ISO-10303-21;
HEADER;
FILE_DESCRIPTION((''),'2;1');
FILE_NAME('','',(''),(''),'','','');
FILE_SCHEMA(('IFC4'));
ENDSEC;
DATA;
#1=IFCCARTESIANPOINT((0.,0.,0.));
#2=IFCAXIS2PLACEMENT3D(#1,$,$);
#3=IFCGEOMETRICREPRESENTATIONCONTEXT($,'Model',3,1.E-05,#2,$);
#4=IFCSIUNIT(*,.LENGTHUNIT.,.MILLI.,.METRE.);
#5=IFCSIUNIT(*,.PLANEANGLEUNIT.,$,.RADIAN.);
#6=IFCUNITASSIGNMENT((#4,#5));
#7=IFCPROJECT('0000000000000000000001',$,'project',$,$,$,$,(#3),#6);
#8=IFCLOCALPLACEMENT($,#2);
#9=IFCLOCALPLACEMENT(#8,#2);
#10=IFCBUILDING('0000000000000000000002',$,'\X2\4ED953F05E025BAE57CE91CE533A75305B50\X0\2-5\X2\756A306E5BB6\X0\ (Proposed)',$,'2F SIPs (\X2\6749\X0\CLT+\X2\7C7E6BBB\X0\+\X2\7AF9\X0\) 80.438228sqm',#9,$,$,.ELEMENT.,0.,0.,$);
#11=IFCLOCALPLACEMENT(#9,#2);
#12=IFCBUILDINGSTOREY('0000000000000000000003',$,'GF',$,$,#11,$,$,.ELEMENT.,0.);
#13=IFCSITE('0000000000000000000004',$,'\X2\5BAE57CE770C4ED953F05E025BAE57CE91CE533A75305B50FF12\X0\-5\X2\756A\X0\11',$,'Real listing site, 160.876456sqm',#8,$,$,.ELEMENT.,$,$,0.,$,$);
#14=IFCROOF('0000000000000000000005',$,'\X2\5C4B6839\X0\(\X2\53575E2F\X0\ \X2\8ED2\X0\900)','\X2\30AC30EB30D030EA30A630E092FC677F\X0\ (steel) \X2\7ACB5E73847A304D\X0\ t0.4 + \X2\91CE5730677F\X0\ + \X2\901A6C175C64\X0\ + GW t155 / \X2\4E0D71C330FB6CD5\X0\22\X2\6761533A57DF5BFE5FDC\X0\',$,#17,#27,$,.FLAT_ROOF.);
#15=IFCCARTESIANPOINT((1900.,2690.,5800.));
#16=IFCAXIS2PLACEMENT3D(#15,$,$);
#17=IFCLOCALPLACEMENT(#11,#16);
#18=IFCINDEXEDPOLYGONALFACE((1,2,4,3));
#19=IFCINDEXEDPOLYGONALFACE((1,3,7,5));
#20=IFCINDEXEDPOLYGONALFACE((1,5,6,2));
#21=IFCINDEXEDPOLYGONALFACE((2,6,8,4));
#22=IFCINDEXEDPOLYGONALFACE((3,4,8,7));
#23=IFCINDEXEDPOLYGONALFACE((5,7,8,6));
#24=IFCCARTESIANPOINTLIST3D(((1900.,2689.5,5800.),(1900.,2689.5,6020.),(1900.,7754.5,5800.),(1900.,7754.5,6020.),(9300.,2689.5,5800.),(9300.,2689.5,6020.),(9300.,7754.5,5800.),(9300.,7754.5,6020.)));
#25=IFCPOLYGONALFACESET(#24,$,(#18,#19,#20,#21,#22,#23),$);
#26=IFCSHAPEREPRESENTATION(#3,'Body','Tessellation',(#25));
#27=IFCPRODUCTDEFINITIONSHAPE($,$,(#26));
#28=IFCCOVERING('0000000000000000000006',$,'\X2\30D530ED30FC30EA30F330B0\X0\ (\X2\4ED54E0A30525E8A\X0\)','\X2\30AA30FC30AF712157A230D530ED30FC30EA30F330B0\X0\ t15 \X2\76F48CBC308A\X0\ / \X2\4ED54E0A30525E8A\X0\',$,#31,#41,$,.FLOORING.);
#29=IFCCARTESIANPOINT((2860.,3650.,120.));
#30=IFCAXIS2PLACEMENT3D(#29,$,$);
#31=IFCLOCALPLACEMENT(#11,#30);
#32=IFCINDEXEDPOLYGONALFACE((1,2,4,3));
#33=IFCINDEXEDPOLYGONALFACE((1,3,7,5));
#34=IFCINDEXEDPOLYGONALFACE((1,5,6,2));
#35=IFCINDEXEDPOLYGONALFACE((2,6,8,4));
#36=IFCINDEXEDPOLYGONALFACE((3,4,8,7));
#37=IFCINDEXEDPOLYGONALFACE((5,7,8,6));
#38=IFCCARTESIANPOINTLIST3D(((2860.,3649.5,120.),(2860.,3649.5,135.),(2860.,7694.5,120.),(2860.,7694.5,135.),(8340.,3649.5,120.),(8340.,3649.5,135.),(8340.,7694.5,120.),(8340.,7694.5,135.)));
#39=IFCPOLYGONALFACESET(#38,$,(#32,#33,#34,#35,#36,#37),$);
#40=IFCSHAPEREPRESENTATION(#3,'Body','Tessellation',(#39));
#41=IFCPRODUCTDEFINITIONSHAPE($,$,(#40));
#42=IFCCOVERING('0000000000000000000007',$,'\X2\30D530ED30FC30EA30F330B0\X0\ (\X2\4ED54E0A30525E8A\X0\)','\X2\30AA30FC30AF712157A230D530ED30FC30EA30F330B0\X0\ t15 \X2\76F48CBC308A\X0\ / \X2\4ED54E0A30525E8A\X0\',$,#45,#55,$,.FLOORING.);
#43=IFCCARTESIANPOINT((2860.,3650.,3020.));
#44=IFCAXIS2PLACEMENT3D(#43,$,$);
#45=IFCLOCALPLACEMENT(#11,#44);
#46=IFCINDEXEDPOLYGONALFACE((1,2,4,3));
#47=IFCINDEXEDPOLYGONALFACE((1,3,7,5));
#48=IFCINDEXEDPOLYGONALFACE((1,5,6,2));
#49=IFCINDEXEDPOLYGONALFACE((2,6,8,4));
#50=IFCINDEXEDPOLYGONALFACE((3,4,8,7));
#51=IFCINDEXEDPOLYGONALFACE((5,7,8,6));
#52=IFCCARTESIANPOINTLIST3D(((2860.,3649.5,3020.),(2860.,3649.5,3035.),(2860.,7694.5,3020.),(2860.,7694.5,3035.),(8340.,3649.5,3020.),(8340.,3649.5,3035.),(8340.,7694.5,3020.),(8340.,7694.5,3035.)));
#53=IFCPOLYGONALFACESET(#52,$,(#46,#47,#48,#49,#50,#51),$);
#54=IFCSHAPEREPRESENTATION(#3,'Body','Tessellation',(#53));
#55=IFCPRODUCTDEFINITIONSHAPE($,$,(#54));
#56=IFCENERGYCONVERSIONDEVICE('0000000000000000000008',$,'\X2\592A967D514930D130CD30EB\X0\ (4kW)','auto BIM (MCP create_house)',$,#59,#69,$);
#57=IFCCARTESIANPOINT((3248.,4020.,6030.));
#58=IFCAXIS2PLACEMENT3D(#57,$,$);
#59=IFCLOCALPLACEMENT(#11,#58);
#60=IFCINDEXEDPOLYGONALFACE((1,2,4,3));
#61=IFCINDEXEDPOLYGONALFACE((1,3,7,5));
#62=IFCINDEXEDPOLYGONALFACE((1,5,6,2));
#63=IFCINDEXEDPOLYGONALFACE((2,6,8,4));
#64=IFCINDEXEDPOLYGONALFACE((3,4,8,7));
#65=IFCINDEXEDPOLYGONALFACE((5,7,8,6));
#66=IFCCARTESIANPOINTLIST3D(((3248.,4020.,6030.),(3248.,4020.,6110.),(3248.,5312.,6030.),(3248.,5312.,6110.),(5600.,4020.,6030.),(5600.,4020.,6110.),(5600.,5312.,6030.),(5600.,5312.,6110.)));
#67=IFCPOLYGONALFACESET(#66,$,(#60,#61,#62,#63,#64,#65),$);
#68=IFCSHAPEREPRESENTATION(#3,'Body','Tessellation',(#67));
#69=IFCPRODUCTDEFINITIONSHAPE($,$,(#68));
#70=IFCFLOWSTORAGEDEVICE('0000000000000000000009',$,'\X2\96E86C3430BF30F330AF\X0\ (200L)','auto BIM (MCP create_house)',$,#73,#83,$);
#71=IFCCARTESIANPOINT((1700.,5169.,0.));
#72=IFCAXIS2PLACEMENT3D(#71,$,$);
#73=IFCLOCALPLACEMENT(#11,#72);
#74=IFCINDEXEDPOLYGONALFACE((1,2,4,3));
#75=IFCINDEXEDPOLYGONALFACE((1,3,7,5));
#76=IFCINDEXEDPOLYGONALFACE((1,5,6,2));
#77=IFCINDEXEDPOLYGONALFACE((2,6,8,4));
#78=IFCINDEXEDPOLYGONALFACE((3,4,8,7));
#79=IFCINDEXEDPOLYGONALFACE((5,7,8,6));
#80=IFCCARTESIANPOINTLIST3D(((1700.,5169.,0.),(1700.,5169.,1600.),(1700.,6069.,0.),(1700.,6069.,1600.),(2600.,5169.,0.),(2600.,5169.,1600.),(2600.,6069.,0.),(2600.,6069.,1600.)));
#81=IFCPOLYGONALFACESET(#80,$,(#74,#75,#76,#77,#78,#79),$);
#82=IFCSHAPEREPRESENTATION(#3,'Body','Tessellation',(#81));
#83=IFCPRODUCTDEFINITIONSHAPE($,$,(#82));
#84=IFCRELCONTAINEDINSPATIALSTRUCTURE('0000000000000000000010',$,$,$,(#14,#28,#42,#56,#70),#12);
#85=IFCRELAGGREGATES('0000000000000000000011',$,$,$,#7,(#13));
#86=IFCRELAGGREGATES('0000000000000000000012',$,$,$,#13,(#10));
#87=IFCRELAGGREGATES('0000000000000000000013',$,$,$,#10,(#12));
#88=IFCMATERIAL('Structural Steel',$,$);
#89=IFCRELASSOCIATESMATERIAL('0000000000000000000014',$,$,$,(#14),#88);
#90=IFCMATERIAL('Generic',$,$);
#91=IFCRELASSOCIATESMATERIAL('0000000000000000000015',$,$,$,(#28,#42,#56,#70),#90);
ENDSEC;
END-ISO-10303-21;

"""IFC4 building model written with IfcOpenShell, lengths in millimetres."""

from ifc_helpers import new_model, si_unit, frame, frame_2d, origin, place, context, project, spatial, rectangle, extrude, material, element, save


model = new_model("IFC4")

# Units and contexts
model_context = context("Model", 3, precision=1e-05, world=origin())
ifc_project = project(units=[si_unit("LENGTHUNIT", "METRE", prefix="MILLI"), si_unit("PLANEANGLEUNIT", "RADIAN")], contexts=[model_context])

# Site, building, storey
site_placement = place(None, origin())
site = spatial("IfcSite", under=ifc_project, at=site_placement, Name="宮城県仙台市宮城野区田子２-5番11", ObjectType="Real listing site, 160.876456sqm", CompositionType="ELEMENT", RefElevation=0.0)
building_placement = place(site_placement, origin())
building = spatial("IfcBuilding", under=site, at=building_placement, Name="仙台市宮城野区田子2-5番の家 (Proposed)", ObjectType="2F SIPs (杉CLT+籾殻+竹) 80.438228sqm", CompositionType="ELEMENT", ElevationOfRefHeight=0.0, ElevationOfTerrain=0.0)
storey_placement = place(building_placement, origin())
storey = spatial("IfcBuildingStorey", under=building, at=storey_placement, Name="GF", CompositionType="ELEMENT", Elevation=0.0)

# Roof
ifc_material_1 = material(Name="Structural Steel")
for number, where, name in (
    (1, (1900.0, 2690.0, 5800.0), "屋根(南帯 軒900)"),
):
    element("IfcRoof", number, at=place(storey_placement, frame(where)), inside=storey, material=ifc_material_1, Name=name, Description="ガルバリウム鋼板 (steel) 立平葺き t0.4 + 野地板 + 通気層 + GW t155 / 不燃・法22条区域対応", PredefinedType="FLAT_ROOF", context=model_context, shape_type="SweptSolid", body=[
        extrude(rectangle(XDim=7400.0, YDim=5065.0, at=frame_2d((3700.0, 2532.0))), frame((1900.0, 2690.0, 5800.0)), (0.0, 0.0, 1.0), 220.0),
    ])

# Coverings
ifc_material_2 = material(Name="Generic")
covering_1_placement = place(storey_placement, frame((2860.0, 3650.0, 120.0)))
element("IfcCovering", 2, at=covering_1_placement, inside=storey, material=ifc_material_2, Name="フローリング (仕上げ床)", Description="オーク無垢フローリング t15 直貼り / 仕上げ床", PredefinedType="FLOORING", context=model_context, shape_type="SweptSolid", body=[
    extrude(rectangle(XDim=5480.0, YDim=4045.0, at=frame_2d((2740.0, 2022.0))), frame((2860.0, 3650.0, 120.0)), (0.0, 0.0, 1.0), 15.0),
])
covering_2_placement = place(storey_placement, frame((2860.0, 3650.0, 3020.0)))
element("IfcCovering", 3, at=covering_2_placement, inside=storey, material=ifc_material_2, Name="フローリング (仕上げ床)", Description="オーク無垢フローリング t15 直貼り / 仕上げ床", PredefinedType="FLOORING", context=model_context, shape_type="SweptSolid", body=[
    extrude(rectangle(XDim=5480.0, YDim=4045.0, at=frame_2d((2740.0, 2022.0))), frame((2860.0, 3650.0, 3020.0)), (0.0, 0.0, 1.0), 15.0),
])

# Energy conversion device
energy_conversion_device_placement = place(storey_placement, frame((3248.0, 4020.0, 6030.0)))
element("IfcEnergyConversionDevice", 4, at=energy_conversion_device_placement, inside=storey, material=ifc_material_2, Name="太陽光パネル (4kW)", Description="auto BIM (MCP create_house)", context=model_context, shape_type="SweptSolid", body=[
    extrude(rectangle(XDim=2352.0, YDim=1292.0, at=frame_2d((1176.0, 646.0))), frame((3248.0, 4020.0, 6030.0)), (0.0, 0.0, 1.0), 80.0),
])

# Flow storage device
flow_storage_device_placement = place(storey_placement, frame((1700.0, 5169.0, 0.0)))
element("IfcFlowStorageDevice", 5, at=flow_storage_device_placement, inside=storey, material=ifc_material_2, Name="雨水タンク (200L)", Description="auto BIM (MCP create_house)", context=model_context, shape_type="SweptSolid", body=[
    extrude(rectangle(XDim=900.0, YDim=900.0, at=frame_2d((450.0, 450.0))), frame((1700.0, 5169.0, 0.0)), (0.0, 0.0, 1.0), 1600.0),
])

save(model, "model.ifc")
